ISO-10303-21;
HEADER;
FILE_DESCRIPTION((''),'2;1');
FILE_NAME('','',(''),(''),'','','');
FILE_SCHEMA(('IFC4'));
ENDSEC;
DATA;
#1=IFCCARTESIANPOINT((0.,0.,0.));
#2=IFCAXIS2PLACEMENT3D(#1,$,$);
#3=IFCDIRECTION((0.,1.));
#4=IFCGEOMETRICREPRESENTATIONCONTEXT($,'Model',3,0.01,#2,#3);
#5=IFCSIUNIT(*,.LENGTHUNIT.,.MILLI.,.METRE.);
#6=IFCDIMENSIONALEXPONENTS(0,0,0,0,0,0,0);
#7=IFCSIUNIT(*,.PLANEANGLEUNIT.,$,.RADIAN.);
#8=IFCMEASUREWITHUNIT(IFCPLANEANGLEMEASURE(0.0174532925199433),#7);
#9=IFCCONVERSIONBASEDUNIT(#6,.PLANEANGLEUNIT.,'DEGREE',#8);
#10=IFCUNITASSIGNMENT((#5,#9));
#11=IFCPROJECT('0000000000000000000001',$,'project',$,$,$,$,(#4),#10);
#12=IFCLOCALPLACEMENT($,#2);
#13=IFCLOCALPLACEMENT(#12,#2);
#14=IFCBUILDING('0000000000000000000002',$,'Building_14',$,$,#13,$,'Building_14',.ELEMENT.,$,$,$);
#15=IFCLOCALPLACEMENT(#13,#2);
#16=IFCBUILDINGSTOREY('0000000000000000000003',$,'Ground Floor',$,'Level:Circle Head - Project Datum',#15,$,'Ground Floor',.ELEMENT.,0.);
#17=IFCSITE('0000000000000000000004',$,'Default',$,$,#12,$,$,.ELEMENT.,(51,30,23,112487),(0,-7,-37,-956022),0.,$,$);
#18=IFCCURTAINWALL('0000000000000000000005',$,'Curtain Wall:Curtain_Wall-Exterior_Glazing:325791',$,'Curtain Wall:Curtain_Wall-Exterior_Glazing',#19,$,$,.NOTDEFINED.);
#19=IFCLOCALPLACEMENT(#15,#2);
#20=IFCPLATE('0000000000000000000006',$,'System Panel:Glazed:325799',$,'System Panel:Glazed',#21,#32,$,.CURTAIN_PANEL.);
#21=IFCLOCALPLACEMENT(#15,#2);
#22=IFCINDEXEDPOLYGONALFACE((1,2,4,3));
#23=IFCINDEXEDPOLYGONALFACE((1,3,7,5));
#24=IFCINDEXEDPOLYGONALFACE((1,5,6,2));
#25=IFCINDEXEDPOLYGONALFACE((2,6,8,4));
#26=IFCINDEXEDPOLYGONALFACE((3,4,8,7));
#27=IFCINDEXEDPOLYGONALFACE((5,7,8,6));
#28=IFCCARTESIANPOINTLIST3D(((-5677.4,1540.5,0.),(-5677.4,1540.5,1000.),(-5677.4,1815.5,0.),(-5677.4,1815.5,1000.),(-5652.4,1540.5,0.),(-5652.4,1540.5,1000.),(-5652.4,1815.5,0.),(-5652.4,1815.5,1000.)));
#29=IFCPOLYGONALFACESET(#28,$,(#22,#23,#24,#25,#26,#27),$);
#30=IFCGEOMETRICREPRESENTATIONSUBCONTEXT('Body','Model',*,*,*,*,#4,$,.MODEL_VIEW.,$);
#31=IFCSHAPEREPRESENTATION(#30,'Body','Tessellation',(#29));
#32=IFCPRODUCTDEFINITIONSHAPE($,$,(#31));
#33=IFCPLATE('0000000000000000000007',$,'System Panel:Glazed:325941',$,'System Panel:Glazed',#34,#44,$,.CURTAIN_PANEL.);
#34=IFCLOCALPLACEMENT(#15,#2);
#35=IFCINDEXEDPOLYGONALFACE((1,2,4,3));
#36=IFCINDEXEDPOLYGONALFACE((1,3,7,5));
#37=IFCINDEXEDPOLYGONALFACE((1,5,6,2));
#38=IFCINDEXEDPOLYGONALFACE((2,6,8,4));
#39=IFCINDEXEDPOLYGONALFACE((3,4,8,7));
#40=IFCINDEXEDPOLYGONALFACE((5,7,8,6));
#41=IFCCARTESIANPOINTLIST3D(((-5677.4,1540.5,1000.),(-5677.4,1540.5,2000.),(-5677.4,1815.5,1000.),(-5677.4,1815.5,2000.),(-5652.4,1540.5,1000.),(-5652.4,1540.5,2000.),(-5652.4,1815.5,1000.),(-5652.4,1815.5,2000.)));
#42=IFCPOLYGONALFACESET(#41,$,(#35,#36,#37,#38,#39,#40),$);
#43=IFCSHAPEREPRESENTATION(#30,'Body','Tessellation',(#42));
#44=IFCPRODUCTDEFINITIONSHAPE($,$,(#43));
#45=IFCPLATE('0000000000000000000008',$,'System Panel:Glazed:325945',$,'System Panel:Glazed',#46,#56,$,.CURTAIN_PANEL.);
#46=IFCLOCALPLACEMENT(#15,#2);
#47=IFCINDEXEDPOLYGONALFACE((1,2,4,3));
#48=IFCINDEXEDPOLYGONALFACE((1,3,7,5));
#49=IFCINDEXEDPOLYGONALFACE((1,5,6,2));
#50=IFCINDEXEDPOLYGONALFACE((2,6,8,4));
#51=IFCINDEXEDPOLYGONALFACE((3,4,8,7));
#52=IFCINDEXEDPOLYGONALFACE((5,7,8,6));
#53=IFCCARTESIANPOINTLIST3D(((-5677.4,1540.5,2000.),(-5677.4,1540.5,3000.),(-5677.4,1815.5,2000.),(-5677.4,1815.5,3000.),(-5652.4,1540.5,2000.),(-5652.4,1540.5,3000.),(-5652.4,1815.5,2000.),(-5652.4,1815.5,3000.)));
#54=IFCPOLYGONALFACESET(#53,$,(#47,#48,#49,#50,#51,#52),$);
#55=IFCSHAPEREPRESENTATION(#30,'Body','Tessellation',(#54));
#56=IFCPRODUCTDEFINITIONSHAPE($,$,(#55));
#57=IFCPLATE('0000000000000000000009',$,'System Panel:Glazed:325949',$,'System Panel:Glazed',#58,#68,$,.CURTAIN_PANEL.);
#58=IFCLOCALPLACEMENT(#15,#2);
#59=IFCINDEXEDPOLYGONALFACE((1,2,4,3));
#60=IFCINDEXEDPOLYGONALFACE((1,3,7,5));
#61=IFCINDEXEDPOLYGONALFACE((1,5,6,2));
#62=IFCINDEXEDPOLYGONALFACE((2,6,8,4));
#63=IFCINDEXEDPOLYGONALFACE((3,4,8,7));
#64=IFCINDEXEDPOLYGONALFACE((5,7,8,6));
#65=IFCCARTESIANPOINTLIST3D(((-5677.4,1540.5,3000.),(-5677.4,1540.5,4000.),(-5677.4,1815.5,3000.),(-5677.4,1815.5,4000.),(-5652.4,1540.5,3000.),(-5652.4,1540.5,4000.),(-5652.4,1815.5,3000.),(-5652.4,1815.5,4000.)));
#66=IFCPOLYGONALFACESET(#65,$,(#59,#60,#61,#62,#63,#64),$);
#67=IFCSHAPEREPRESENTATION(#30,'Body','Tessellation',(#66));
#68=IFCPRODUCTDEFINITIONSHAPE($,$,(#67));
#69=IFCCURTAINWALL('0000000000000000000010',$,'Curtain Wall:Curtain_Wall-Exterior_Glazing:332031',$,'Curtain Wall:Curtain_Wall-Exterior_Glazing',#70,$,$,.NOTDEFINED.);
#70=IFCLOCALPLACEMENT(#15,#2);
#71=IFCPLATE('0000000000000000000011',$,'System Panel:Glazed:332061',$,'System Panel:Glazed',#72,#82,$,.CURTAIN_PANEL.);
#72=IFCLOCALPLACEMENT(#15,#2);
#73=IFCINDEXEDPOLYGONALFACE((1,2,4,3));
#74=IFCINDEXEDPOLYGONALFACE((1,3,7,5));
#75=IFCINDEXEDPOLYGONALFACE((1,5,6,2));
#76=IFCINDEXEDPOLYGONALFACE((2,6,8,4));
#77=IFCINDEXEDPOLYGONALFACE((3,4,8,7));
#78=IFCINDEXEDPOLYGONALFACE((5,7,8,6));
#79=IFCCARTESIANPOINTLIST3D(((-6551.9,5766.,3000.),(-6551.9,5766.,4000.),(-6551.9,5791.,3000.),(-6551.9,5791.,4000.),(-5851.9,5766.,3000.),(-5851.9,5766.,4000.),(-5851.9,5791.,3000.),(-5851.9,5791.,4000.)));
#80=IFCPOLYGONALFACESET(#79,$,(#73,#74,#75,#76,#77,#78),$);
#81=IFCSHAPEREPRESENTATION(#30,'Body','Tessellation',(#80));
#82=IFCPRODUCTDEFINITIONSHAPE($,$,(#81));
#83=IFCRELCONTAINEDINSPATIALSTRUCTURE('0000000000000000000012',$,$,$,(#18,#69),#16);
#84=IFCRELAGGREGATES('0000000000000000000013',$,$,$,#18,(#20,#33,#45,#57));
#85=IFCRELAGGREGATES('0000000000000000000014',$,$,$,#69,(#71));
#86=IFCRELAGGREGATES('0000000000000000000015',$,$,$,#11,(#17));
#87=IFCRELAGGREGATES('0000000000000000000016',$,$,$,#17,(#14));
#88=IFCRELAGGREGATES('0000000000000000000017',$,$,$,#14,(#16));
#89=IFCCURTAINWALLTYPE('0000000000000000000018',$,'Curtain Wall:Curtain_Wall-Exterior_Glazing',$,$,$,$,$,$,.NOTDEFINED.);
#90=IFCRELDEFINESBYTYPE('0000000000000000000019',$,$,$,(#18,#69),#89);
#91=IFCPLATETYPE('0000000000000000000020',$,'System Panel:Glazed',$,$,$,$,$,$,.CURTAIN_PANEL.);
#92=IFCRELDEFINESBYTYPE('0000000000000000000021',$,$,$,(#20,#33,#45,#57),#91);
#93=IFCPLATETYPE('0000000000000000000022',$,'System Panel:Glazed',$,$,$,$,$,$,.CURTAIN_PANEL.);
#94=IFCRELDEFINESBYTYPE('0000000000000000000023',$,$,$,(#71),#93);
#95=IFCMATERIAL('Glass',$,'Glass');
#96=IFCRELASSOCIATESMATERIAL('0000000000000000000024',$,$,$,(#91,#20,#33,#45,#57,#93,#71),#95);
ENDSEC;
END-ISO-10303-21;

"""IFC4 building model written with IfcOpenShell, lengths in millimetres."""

from ifc_helpers import new_model, entity, si_unit, converted_unit, direction, frame, origin, place, context, subcontext, project, spatial, indexed_curve, outline, extrude, source, transform, mapped, material, type_object, type_shapes, element, aggregate, save


model = new_model("IFC4")

# Units and contexts
model_context = context("Model", 3, precision=0.01, world=origin(), true_north=direction((0.0, 1.0)))
body_context = subcontext(model_context, "Body", "Model", "MODEL_VIEW")
ifc_project = project(units=[si_unit("LENGTHUNIT", "METRE", prefix="MILLI"), converted_unit("PLANEANGLEUNIT", "DEGREE", entity("IfcPlaneAngleMeasure", 0.0174532925199433), si_unit("PLANEANGLEUNIT", "RADIAN"), dimensions=[0, 0, 0, 0, 0, 0, 0])], contexts=[model_context])

# Site, building, storey
site_placement = place(None, origin())
site = spatial("IfcSite", under=ifc_project, at=site_placement, Name="Default", CompositionType="ELEMENT", RefLatitude=(51, 30, 23, 112487), RefLongitude=(0, -7, -37, -956022), RefElevation=0.0)
building_placement = place(site_placement, origin())
building = spatial("IfcBuilding", under=site, at=building_placement, Name="Building_14", LongName="Building_14", CompositionType="ELEMENT")
storey_placement = place(building_placement, origin())
storey = spatial("IfcBuildingStorey", under=building, at=storey_placement, Name="Ground Floor", ObjectType="Level:Circle Head - Project Datum", LongName="Ground Floor", CompositionType="ELEMENT", Elevation=0.0)

# Curtain wall
curtain_wall_type = type_object("IfcCurtainWallType", Name="Curtain Wall:Curtain_Wall-Exterior_Glazing", PredefinedType="NOTDEFINED")
curtain_wall_1_placement = place(storey_placement, origin())
curtain_wall_1 = element("IfcCurtainWall", 1, at=curtain_wall_1_placement, inside=storey, type_object=curtain_wall_type, Name="Curtain Wall:Curtain_Wall-Exterior_Glazing:325791", ObjectType="Curtain Wall:Curtain_Wall-Exterior_Glazing", PredefinedType="NOTDEFINED")
ifc_material = material(Name="Glass", Category="Glass")

# Plates
plate_type_1 = type_object("IfcPlateType", Name="System Panel:Glazed", PredefinedType="CURTAIN_PANEL", material=ifc_material)
shared_shape_1 = source(origin(), body_context, "Body", "SweptSolid", [
    extrude(outline(indexed_curve([(-12.5, -137.5), (12.5, -137.5), (12.5, 137.5), (-12.5, 137.5), (-12.5, -137.5)], self_intersect=False)), frame((0.0, -37.0, 0.0), z_axis=(0.0, 0.0, 1.0), x_axis=(0.0, 1.0, 0.0)), (0.0, 0.0, 1.0), 1000.0),
])
type_shapes(plate_type_1, [shared_shape_1])
plate_1_placement = place(curtain_wall_1_placement, frame((-5701.9, 1678.0, 0.0), z_axis=(0.0, 0.0, 1.0), x_axis=(0.0, 1.0, 0.0)))
plate_1 = element("IfcPlate", 2, at=plate_1_placement, type_object=plate_type_1, material=ifc_material, Name="System Panel:Glazed:325799", ObjectType="System Panel:Glazed", PredefinedType="CURTAIN_PANEL", context=body_context, shape_type="MappedRepresentation", body=[
    mapped(shared_shape_1, transform((0.0, 0.0, 0.0), scale=1.0)),
])
plate_2_placement = place(curtain_wall_1_placement, frame((-5701.9, 1678.0, 1000.0), z_axis=(0.0, 0.0, 1.0), x_axis=(0.0, 1.0, 0.0)))
plate_2 = element("IfcPlate", 3, at=plate_2_placement, type_object=plate_type_1, material=ifc_material, Name="System Panel:Glazed:325941", ObjectType="System Panel:Glazed", PredefinedType="CURTAIN_PANEL", context=body_context, shape_type="MappedRepresentation", body=[
    mapped(shared_shape_1, transform((0.0, 0.0, 0.0), scale=1.0)),
])
plate_3_placement = place(curtain_wall_1_placement, frame((-5701.9, 1678.0, 2000.0), z_axis=(0.0, 0.0, 1.0), x_axis=(0.0, 1.0, 0.0)))
plate_3 = element("IfcPlate", 4, at=plate_3_placement, type_object=plate_type_1, material=ifc_material, Name="System Panel:Glazed:325945", ObjectType="System Panel:Glazed", PredefinedType="CURTAIN_PANEL", context=body_context, shape_type="MappedRepresentation", body=[
    mapped(shared_shape_1, transform((0.0, 0.0, 0.0), scale=1.0)),
])
plate_4_placement = place(curtain_wall_1_placement, frame((-5701.9, 1678.0, 3000.0), z_axis=(0.0, 0.0, 1.0), x_axis=(0.0, 1.0, 0.0)))
plate_4 = element("IfcPlate", 5, at=plate_4_placement, type_object=plate_type_1, material=ifc_material, Name="System Panel:Glazed:325949", ObjectType="System Panel:Glazed", PredefinedType="CURTAIN_PANEL", context=body_context, shape_type="MappedRepresentation", body=[
    mapped(shared_shape_1, transform((0.0, 0.0, 0.0), scale=1.0)),
])
aggregate(curtain_wall_1, [plate_1, plate_2, plate_3, plate_4])

# Curtain wall, plate
curtain_wall_2_placement = place(storey_placement, origin())
curtain_wall_2 = element("IfcCurtainWall", 6, at=curtain_wall_2_placement, inside=storey, type_object=curtain_wall_type, Name="Curtain Wall:Curtain_Wall-Exterior_Glazing:332031", ObjectType="Curtain Wall:Curtain_Wall-Exterior_Glazing", PredefinedType="NOTDEFINED")
plate_type_2 = type_object("IfcPlateType", Name="System Panel:Glazed", PredefinedType="CURTAIN_PANEL", material=ifc_material)
shared_shape_2 = source(origin(), body_context, "Body", "SweptSolid", [
    extrude(outline(indexed_curve([(-12.5, -350.0), (12.5, -350.0), (12.5, 350.0), (-12.5, 350.0), (-12.5, -350.0)], self_intersect=False)), frame((0.0, -37.0, 0.0), z_axis=(0.0, 0.0, 1.0), x_axis=(0.0, 1.0, 0.0)), (0.0, 0.0, 1.0), 1000.0),
])
type_shapes(plate_type_2, [shared_shape_2])
plate_5_placement = place(curtain_wall_2_placement, frame((-6201.9, 5815.5, 3000.0)))
plate_5 = element("IfcPlate", 7, at=plate_5_placement, type_object=plate_type_2, material=ifc_material, Name="System Panel:Glazed:332061", ObjectType="System Panel:Glazed", PredefinedType="CURTAIN_PANEL", context=body_context, shape_type="MappedRepresentation", body=[
    mapped(shared_shape_2, transform((0.0, 0.0, 0.0), scale=1.0)),
])
aggregate(curtain_wall_2, [plate_5])

save(model, "model.ifc")
